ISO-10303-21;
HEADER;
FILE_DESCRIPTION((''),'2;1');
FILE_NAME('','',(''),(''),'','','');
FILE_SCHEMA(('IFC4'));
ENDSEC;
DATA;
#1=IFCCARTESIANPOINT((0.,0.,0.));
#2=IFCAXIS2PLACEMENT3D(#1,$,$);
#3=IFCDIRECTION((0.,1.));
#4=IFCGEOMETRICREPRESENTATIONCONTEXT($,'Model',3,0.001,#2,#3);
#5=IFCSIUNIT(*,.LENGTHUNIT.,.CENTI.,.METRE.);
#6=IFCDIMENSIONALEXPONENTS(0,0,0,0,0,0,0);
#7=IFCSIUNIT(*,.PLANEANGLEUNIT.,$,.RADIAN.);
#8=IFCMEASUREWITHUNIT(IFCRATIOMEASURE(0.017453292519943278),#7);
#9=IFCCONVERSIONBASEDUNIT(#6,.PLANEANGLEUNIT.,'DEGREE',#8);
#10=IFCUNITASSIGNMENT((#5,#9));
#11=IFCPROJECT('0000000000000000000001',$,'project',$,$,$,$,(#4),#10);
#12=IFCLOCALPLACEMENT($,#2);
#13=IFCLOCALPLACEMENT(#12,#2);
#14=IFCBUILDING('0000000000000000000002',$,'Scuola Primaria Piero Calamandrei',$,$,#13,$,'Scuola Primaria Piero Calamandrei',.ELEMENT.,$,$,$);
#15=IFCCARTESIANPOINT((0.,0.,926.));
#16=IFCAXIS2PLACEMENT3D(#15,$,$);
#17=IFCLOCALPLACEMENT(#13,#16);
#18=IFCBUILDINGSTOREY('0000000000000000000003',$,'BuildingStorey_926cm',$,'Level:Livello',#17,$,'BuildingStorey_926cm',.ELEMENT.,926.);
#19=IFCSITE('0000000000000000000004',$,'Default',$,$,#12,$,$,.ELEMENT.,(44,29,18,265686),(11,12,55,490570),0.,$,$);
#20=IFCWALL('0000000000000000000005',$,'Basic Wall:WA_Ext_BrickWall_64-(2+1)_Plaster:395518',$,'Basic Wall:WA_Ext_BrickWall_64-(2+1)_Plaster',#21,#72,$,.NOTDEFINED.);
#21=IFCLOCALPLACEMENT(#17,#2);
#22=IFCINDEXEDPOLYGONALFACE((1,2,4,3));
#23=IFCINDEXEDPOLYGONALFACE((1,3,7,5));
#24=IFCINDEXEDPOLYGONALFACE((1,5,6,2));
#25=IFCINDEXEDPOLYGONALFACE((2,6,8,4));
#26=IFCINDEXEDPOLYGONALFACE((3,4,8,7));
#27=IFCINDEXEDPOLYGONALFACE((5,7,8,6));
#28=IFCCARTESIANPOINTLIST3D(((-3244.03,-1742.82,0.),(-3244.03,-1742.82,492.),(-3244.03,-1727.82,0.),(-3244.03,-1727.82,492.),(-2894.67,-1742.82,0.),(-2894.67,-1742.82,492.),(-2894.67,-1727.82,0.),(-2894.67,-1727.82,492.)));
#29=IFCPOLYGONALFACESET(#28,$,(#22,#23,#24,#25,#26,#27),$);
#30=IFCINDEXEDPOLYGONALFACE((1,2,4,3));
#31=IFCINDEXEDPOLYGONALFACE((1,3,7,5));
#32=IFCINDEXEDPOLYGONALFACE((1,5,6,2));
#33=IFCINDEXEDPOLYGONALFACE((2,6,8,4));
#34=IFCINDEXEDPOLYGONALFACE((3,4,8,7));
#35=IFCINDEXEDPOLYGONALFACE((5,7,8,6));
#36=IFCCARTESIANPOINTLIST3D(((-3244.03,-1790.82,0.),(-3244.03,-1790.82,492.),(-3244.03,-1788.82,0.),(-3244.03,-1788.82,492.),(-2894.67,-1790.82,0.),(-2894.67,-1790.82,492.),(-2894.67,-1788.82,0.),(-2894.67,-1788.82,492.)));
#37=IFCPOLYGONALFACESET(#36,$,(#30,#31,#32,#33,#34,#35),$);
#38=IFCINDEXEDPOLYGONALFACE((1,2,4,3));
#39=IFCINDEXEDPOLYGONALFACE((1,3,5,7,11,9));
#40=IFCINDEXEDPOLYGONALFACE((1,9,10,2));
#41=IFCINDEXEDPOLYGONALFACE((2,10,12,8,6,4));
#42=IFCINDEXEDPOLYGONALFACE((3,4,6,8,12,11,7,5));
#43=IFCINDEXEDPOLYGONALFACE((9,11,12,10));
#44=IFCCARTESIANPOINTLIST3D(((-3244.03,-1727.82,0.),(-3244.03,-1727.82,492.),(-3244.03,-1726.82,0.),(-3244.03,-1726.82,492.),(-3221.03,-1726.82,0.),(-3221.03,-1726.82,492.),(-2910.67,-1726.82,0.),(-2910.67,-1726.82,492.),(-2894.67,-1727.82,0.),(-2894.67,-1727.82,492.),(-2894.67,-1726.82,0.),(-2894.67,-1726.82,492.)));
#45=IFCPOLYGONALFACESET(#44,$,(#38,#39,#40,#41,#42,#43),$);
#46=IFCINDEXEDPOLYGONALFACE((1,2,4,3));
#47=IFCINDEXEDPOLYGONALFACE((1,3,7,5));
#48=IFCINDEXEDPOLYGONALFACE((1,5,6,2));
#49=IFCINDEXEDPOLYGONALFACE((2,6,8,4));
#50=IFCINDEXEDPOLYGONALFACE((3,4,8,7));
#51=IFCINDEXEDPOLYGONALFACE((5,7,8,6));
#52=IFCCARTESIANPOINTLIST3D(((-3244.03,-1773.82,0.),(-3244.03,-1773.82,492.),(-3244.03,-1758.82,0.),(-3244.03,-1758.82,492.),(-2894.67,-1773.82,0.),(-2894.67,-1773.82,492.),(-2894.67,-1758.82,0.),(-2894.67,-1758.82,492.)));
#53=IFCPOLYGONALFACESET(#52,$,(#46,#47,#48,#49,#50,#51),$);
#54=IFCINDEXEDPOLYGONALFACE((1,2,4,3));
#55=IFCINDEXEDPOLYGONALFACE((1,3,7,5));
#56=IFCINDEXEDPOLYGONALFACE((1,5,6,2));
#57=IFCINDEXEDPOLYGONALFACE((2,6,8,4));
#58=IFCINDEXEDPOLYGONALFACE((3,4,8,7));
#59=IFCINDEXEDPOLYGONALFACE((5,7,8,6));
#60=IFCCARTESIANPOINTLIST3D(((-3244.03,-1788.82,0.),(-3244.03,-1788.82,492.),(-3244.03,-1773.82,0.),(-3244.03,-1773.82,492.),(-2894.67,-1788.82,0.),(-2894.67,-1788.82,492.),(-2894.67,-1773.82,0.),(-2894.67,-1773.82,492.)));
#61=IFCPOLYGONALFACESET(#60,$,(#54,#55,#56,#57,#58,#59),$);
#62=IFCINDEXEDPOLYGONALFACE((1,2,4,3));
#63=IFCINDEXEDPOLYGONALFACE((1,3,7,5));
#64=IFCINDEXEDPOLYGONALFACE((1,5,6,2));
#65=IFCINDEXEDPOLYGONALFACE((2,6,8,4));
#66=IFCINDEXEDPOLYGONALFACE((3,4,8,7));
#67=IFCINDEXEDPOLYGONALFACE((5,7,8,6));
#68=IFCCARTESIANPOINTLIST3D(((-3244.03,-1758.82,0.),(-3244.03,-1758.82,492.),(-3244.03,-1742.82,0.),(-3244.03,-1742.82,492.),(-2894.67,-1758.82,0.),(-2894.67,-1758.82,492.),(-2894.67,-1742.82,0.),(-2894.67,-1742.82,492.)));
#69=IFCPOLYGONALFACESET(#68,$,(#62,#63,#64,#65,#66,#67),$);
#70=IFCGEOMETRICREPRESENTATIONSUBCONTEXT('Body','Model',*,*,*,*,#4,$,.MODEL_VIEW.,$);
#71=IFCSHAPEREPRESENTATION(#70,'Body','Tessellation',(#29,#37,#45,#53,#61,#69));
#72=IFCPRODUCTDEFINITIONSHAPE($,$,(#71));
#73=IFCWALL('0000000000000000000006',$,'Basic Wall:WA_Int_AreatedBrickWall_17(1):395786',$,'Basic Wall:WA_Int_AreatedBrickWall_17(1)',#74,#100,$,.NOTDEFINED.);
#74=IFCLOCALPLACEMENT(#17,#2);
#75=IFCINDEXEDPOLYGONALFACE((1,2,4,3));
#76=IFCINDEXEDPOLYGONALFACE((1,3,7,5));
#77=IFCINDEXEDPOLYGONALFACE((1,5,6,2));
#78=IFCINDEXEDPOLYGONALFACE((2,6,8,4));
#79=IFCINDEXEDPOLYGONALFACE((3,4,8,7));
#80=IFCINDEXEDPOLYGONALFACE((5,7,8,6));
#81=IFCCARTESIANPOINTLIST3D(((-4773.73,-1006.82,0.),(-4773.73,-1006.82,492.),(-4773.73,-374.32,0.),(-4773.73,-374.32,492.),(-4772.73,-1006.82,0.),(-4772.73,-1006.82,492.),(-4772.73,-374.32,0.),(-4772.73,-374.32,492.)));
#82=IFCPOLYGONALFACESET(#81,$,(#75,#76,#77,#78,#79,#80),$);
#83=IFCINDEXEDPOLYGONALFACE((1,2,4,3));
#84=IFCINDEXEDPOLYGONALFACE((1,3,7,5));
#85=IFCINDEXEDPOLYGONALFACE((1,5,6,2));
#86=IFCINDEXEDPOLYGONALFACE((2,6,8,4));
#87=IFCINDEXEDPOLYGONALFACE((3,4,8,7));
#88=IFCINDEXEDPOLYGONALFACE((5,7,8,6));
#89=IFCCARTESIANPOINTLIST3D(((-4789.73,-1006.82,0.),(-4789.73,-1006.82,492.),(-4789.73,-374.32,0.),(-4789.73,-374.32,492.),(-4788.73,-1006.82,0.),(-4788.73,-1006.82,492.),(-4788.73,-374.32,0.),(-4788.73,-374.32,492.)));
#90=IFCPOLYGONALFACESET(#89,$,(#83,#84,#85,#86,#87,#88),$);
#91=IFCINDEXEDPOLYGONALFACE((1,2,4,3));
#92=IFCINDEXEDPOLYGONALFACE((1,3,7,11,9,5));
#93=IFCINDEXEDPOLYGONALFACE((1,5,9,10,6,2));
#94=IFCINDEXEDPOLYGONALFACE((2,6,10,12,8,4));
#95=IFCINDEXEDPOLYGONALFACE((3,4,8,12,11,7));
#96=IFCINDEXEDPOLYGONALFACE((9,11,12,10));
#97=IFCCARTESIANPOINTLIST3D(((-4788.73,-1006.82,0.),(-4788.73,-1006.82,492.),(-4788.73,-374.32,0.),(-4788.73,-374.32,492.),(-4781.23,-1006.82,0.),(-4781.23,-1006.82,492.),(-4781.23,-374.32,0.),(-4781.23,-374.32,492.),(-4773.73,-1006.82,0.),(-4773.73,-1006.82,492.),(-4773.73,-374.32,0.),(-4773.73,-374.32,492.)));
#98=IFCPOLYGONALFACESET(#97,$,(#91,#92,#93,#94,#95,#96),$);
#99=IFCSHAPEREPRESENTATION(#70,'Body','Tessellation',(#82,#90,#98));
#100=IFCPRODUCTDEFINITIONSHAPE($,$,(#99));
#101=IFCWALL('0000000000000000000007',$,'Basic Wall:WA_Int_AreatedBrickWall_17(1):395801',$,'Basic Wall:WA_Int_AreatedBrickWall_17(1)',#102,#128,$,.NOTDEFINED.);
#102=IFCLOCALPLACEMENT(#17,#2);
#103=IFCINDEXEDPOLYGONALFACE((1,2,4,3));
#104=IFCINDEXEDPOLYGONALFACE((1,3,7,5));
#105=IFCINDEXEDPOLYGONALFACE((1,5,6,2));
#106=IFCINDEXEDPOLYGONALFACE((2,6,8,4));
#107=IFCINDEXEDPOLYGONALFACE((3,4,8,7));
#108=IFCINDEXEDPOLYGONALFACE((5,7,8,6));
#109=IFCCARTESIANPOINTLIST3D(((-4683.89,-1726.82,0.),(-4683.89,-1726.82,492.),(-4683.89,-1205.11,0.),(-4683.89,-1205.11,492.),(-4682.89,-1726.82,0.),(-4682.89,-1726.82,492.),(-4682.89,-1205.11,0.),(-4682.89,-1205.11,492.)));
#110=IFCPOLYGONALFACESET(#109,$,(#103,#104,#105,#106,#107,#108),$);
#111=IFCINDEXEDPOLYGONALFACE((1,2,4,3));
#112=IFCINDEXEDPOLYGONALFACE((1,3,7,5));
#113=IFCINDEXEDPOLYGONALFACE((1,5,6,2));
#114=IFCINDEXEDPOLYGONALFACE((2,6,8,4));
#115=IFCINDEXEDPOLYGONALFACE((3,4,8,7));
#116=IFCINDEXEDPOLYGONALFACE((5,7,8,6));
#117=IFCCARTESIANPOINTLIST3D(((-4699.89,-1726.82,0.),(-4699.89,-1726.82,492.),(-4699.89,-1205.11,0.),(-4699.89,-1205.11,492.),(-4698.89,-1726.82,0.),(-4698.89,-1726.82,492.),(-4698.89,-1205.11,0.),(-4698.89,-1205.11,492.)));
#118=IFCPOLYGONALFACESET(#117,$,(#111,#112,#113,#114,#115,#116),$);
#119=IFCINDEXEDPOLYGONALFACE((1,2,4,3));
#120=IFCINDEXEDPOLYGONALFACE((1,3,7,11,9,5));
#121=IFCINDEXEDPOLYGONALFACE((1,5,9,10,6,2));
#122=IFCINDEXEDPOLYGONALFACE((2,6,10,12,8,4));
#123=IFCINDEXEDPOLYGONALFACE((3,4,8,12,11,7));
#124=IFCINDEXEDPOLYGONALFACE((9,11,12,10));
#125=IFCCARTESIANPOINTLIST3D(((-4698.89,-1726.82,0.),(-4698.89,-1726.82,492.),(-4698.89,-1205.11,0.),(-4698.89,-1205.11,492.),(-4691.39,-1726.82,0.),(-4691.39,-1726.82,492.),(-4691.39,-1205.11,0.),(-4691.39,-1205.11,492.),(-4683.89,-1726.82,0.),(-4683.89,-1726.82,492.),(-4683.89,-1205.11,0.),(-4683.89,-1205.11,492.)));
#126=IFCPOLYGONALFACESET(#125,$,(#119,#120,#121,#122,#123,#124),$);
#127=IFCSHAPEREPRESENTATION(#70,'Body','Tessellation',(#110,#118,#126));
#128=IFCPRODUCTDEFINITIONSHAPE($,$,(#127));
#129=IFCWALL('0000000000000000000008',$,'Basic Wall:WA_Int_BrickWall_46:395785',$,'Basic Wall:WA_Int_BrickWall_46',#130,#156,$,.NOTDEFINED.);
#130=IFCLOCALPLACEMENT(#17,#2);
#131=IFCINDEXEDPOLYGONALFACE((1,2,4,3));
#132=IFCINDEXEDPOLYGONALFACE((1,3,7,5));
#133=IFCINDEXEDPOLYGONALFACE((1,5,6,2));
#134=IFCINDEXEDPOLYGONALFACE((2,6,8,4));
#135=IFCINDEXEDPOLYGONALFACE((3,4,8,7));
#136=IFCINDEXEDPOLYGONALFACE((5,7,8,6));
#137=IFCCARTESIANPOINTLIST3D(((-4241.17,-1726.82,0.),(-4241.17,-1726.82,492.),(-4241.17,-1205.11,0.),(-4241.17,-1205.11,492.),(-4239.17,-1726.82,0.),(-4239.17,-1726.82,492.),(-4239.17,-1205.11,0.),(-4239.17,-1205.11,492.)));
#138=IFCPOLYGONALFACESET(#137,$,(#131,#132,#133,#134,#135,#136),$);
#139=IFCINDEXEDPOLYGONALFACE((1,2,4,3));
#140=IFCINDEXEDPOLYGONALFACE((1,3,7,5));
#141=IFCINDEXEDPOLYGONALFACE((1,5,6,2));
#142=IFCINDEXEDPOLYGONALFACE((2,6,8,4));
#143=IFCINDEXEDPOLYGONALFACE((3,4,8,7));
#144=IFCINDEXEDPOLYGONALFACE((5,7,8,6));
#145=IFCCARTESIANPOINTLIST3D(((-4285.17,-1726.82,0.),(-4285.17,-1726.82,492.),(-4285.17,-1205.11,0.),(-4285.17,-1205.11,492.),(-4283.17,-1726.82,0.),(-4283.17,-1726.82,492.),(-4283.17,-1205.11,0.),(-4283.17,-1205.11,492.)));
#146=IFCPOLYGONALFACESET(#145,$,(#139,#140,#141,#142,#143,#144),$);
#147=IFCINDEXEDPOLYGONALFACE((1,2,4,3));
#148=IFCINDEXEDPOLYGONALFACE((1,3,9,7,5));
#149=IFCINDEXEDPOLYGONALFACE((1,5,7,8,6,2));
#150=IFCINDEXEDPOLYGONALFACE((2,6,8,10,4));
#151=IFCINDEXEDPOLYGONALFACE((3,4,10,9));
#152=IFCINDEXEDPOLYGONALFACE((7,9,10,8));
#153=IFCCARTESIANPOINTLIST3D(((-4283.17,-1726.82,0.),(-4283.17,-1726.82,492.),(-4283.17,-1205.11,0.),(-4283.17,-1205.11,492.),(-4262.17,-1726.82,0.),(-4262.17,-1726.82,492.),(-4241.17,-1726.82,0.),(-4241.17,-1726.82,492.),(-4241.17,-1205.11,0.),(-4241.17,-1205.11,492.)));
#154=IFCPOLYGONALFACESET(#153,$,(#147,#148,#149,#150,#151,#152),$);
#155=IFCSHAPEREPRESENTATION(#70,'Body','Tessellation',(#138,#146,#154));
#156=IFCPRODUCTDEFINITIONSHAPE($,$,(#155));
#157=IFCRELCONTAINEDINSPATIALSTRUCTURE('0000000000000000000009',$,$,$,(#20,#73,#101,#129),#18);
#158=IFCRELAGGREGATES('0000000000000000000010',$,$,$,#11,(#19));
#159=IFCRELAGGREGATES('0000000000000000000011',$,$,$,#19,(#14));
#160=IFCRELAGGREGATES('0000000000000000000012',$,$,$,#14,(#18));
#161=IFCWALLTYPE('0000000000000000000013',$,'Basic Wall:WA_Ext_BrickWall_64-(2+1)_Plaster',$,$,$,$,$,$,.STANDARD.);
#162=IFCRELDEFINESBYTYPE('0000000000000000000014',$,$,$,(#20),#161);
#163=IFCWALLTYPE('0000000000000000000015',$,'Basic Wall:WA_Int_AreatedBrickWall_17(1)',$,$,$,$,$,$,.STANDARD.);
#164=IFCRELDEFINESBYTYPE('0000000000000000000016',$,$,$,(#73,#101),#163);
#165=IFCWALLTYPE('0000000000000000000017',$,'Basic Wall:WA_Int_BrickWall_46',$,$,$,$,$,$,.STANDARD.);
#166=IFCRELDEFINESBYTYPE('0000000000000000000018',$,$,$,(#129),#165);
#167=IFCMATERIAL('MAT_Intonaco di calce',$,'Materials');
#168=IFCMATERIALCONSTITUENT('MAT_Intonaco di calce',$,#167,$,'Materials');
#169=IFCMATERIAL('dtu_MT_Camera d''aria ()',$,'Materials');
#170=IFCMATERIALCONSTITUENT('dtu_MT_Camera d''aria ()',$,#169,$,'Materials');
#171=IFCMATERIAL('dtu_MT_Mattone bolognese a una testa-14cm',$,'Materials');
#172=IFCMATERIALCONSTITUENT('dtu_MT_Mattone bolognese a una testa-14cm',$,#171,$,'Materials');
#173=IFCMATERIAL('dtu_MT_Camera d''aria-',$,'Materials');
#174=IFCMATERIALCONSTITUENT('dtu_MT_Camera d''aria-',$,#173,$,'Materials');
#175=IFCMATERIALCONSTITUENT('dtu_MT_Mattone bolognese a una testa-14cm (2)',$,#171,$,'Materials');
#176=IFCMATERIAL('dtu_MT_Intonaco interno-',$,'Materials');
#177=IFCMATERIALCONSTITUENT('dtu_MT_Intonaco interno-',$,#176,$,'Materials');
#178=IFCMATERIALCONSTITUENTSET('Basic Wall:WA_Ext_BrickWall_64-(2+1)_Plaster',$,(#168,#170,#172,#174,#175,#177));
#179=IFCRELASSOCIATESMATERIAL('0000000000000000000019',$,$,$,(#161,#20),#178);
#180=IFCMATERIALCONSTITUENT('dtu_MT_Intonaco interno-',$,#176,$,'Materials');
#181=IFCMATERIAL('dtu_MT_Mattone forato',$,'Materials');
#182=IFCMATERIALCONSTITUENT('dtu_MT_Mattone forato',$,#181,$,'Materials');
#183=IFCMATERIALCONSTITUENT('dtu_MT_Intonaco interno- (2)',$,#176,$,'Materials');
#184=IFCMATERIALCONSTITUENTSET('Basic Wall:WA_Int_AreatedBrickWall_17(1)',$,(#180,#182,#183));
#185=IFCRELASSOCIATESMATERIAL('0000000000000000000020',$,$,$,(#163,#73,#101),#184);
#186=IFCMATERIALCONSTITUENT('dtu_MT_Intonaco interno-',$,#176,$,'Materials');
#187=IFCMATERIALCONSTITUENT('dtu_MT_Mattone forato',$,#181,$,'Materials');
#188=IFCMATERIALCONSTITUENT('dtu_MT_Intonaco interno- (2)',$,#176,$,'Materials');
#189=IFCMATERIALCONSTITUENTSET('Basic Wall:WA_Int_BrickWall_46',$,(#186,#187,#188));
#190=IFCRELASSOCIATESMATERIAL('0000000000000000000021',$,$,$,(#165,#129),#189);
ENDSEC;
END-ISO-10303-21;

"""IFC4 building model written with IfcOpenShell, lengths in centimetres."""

from ifc_helpers import new_model, entity, si_unit, converted_unit, direction, frame, origin, place, context, subcontext, project, spatial, indexed_curve, outline, extrude, material, constituent, constituent_set, type_object, element, save


model = new_model("IFC4")

# Units and contexts
model_context = context("Model", 3, precision=0.001, world=origin(), true_north=direction((0.0, 1.0)))
body_context = subcontext(model_context, "Body", "Model", "MODEL_VIEW")
ifc_project = project(units=[si_unit("LENGTHUNIT", "METRE", prefix="CENTI"), converted_unit("PLANEANGLEUNIT", "DEGREE", entity("IfcRatioMeasure", 0.017453292519943278), si_unit("PLANEANGLEUNIT", "RADIAN"), dimensions=[0, 0, 0, 0, 0, 0, 0])], contexts=[model_context])

# Site, building, storey
site_placement = place(None, origin())
site = spatial("IfcSite", under=ifc_project, at=site_placement, Name="Default", CompositionType="ELEMENT", RefLatitude=(44, 29, 18, 265686), RefLongitude=(11, 12, 55, 490570), RefElevation=0.0)
building_placement = place(site_placement, origin())
building = spatial("IfcBuilding", under=site, at=building_placement, Name="Scuola Primaria Piero Calamandrei", LongName="Scuola Primaria Piero Calamandrei", CompositionType="ELEMENT")
storey_placement = place(building_placement, frame((0.0, 0.0, 926.0)))
storey = spatial("IfcBuildingStorey", under=building, at=storey_placement, Name="BuildingStorey_926cm", ObjectType="Level:Livello", LongName="BuildingStorey_926cm", CompositionType="ELEMENT", Elevation=926.0)

# Wall
ifc_material_1 = material(Name="MAT_Intonaco di calce", Category="Materials")
ifc_constituent_1 = constituent(ifc_material_1, Name="MAT_Intonaco di calce", Category="Materials")
ifc_material_2 = material(Name="dtu_MT_Camera d'aria ()", Category="Materials")
ifc_constituent_2 = constituent(ifc_material_2, Name="dtu_MT_Camera d'aria ()", Category="Materials")
ifc_material_3 = material(Name="dtu_MT_Mattone bolognese a una testa-14cm", Category="Materials")
ifc_constituent_3 = constituent(ifc_material_3, Name="dtu_MT_Mattone bolognese a una testa-14cm", Category="Materials")
ifc_material_4 = material(Name="dtu_MT_Camera d'aria-", Category="Materials")
ifc_constituent_4 = constituent(ifc_material_4, Name="dtu_MT_Camera d'aria-", Category="Materials")
ifc_constituent_5 = constituent(ifc_material_3, Name="dtu_MT_Mattone bolognese a una testa-14cm (2)", Category="Materials")
ifc_material_5 = material(Name="dtu_MT_Intonaco interno-", Category="Materials")
ifc_constituent_6 = constituent(ifc_material_5, Name="dtu_MT_Intonaco interno-", Category="Materials")
ifc_constituent_set_1 = constituent_set(constituents=[ifc_constituent_1, ifc_constituent_2, ifc_constituent_3, ifc_constituent_4, ifc_constituent_5, ifc_constituent_6], Name="Basic Wall:WA_Ext_BrickWall_64-(2+1)_Plaster")
wall_type_1 = type_object("IfcWallType", Name="Basic Wall:WA_Ext_BrickWall_64-(2+1)_Plaster", PredefinedType="STANDARD", material=ifc_constituent_set_1)
wall_1_placement = place(storey_placement, frame((-2894.67, -1758.82, 0.0), z_axis=(0.0, 0.0, 1.0), x_axis=(-1.0, 0.0, 0.0)))
element("IfcWall", 1, at=wall_1_placement, inside=storey, type_object=wall_type_1, material=ifc_constituent_set_1, Name="Basic Wall:WA_Ext_BrickWall_64-(2+1)_Plaster:395518", ObjectType="Basic Wall:WA_Ext_BrickWall_64-(2+1)_Plaster", PredefinedType="NOTDEFINED", context=body_context, shape_type="SweptSolid", body=[
    extrude(outline(indexed_curve([(-174.68, -7.5), (174.68, -7.5), (174.68, 7.5), (-174.68, 7.5), (-174.68, -7.5)], self_intersect=False)), frame((174.68, -23.5, 0.0)), (0.0, 0.0, 1.0), 492.0),
    extrude(outline(indexed_curve([(-1.0, -174.68), (1.0, -174.68), (1.0, 174.68), (-1.0, 174.68), (-1.0, -174.68)], self_intersect=False)), frame((174.68, 31.0, 0.0), z_axis=(0.0, 0.0, 1.0), x_axis=(0.0, -1.0, 0.0)), (0.0, 0.0, 1.0), 492.0),
    extrude(outline(indexed_curve([(-157.51, -0.33), (152.85, -0.33), (175.85, -0.33), (175.85, 0.67), (-173.51, 0.67), (-173.51, -0.33), (-157.51, -0.33)], self_intersect=False)), frame((173.51, -31.67, 0.0)), (0.0, 0.0, 1.0), 492.0),
    extrude(outline(indexed_curve([(-174.68, -7.5), (174.68, -7.5), (174.68, 7.5), (-174.68, 7.5), (-174.68, -7.5)], self_intersect=False)), frame((174.68, 7.5, 0.0)), (0.0, 0.0, 1.0), 492.0),
    extrude(outline(indexed_curve([(-174.68, -7.5), (174.68, -7.5), (174.68, 7.5), (-174.68, 7.5), (-174.68, -7.5)], self_intersect=False)), frame((174.68, 22.5, 0.0)), (0.0, 0.0, 1.0), 492.0),
    extrude(outline(indexed_curve([(-174.68, -8.0), (174.68, -8.0), (174.68, 8.0), (-174.68, 8.0), (-174.68, -8.0)], self_intersect=False)), frame((174.68, -8.0, 0.0)), (0.0, 0.0, 1.0), 492.0),
])

# Shared definitions
ifc_constituent_7 = constituent(ifc_material_5, Name="dtu_MT_Intonaco interno-", Category="Materials")
ifc_material_6 = material(Name="dtu_MT_Mattone forato", Category="Materials")
ifc_constituent_8 = constituent(ifc_material_6, Name="dtu_MT_Mattone forato", Category="Materials")
ifc_constituent_9 = constituent(ifc_material_5, Name="dtu_MT_Intonaco interno- (2)", Category="Materials")
ifc_constituent_set_2 = constituent_set(constituents=[ifc_constituent_7, ifc_constituent_8, ifc_constituent_9], Name="Basic Wall:WA_Int_AreatedBrickWall_17(1)")
wall_type_2 = type_object("IfcWallType", Name="Basic Wall:WA_Int_AreatedBrickWall_17(1)", PredefinedType="STANDARD", material=ifc_constituent_set_2)

# Walls
wall_2_placement = place(storey_placement, frame((-4781.23, -1006.82, 0.0), z_axis=(0.0, 0.0, 1.0), x_axis=(0.0, 1.0, 0.0)))
element("IfcWall", 2, at=wall_2_placement, inside=storey, type_object=wall_type_2, material=ifc_constituent_set_2, Name="Basic Wall:WA_Int_AreatedBrickWall_17(1):395786", ObjectType="Basic Wall:WA_Int_AreatedBrickWall_17(1)", PredefinedType="NOTDEFINED", context=body_context, shape_type="SweptSolid", body=[
    extrude(outline(indexed_curve([(-0.5, -316.25), (0.5, -316.25), (0.5, 316.25), (-0.5, 316.25), (-0.5, -316.25)], self_intersect=False)), frame((316.25, -8.0, 0.0), z_axis=(0.0, 0.0, 1.0), x_axis=(0.0, 1.0, 0.0)), (0.0, 0.0, 1.0), 492.0),
    extrude(outline(indexed_curve([(-0.5, -316.25), (0.5, -316.25), (0.5, 316.25), (-0.5, 316.25), (-0.5, -316.25)], self_intersect=False)), frame((316.25, 8.0, 0.0), z_axis=(0.0, 0.0, 1.0), x_axis=(0.0, -1.0, 0.0)), (0.0, 0.0, 1.0), 492.0),
    extrude(outline(indexed_curve([(-316.25, -7.5), (316.25, -7.5), (316.25, 0.0), (316.25, 7.5), (-316.25, 7.5), (-316.25, 0.0), (-316.25, -7.5)], self_intersect=False)), frame((316.25, 0.0, 0.0)), (0.0, 0.0, 1.0), 492.0),
])
wall_3_placement = place(storey_placement, frame((-4691.39, -1726.82, 0.0), z_axis=(0.0, 0.0, 1.0), x_axis=(0.0, 1.0, 0.0)))
element("IfcWall", 3, at=wall_3_placement, inside=storey, type_object=wall_type_2, material=ifc_constituent_set_2, Name="Basic Wall:WA_Int_AreatedBrickWall_17(1):395801", ObjectType="Basic Wall:WA_Int_AreatedBrickWall_17(1)", PredefinedType="NOTDEFINED", context=body_context, shape_type="SweptSolid", body=[
    extrude(outline(indexed_curve([(-0.5, -260.86), (0.5, -260.86), (0.5, 260.86), (-0.5, 260.86), (-0.5, -260.86)], self_intersect=False)), frame((260.86, -8.0, 0.0), z_axis=(0.0, 0.0, 1.0), x_axis=(0.0, 1.0, 0.0)), (0.0, 0.0, 1.0), 492.0),
    extrude(outline(indexed_curve([(-0.5, -260.86), (0.5, -260.86), (0.5, 260.86), (-0.5, 260.86), (-0.5, -260.86)], self_intersect=False)), frame((260.86, 8.0, 0.0), z_axis=(0.0, 0.0, 1.0), x_axis=(0.0, -1.0, 0.0)), (0.0, 0.0, 1.0), 492.0),
    extrude(outline(indexed_curve([(-260.86, -7.5), (260.86, -7.5), (260.86, 0.0), (260.86, 7.5), (-260.86, 7.5), (-260.86, 0.0), (-260.86, -7.5)], self_intersect=False)), frame((260.86, 0.0, 0.0)), (0.0, 0.0, 1.0), 492.0),
])
ifc_constituent_10 = constituent(ifc_material_5, Name="dtu_MT_Intonaco interno-", Category="Materials")
ifc_constituent_11 = constituent(ifc_material_6, Name="dtu_MT_Mattone forato", Category="Materials")
ifc_constituent_12 = constituent(ifc_material_5, Name="dtu_MT_Intonaco interno- (2)", Category="Materials")
ifc_constituent_set_3 = constituent_set(constituents=[ifc_constituent_10, ifc_constituent_11, ifc_constituent_12], Name="Basic Wall:WA_Int_BrickWall_46")
wall_type_3 = type_object("IfcWallType", Name="Basic Wall:WA_Int_BrickWall_46", PredefinedType="STANDARD", material=ifc_constituent_set_3)

# Wall
wall_4_placement = place(storey_placement, frame((-4262.17, -1726.82, 0.0), z_axis=(0.0, 0.0, 1.0), x_axis=(0.0, 1.0, 0.0)))
element("IfcWall", 4, at=wall_4_placement, inside=storey, type_object=wall_type_3, material=ifc_constituent_set_3, Name="Basic Wall:WA_Int_BrickWall_46:395785", ObjectType="Basic Wall:WA_Int_BrickWall_46", PredefinedType="NOTDEFINED", context=body_context, shape_type="SweptSolid", body=[
    extrude(outline(indexed_curve([(-1.0, -260.86), (1.0, -260.86), (1.0, 260.86), (-1.0, 260.86), (-1.0, -260.86)], self_intersect=False)), frame((260.86, -22.0, 0.0), z_axis=(0.0, 0.0, 1.0), x_axis=(0.0, 1.0, 0.0)), (0.0, 0.0, 1.0), 492.0),
    extrude(outline(indexed_curve([(-1.0, -260.86), (1.0, -260.86), (1.0, 260.86), (-1.0, 260.86), (-1.0, -260.86)], self_intersect=False)), frame((260.86, 22.0, 0.0), z_axis=(0.0, 0.0, 1.0), x_axis=(0.0, -1.0, 0.0)), (0.0, 0.0, 1.0), 492.0),
    extrude(outline(indexed_curve([(-208.69, -21.0), (313.03, -21.0), (313.03, 21.0), (-208.69, 21.0), (-208.69, 0.0), (-208.69, -21.0)], self_intersect=False)), frame((208.69, 0.0, 0.0)), (0.0, 0.0, 1.0), 492.0),
])

save(model, "model.ifc")
